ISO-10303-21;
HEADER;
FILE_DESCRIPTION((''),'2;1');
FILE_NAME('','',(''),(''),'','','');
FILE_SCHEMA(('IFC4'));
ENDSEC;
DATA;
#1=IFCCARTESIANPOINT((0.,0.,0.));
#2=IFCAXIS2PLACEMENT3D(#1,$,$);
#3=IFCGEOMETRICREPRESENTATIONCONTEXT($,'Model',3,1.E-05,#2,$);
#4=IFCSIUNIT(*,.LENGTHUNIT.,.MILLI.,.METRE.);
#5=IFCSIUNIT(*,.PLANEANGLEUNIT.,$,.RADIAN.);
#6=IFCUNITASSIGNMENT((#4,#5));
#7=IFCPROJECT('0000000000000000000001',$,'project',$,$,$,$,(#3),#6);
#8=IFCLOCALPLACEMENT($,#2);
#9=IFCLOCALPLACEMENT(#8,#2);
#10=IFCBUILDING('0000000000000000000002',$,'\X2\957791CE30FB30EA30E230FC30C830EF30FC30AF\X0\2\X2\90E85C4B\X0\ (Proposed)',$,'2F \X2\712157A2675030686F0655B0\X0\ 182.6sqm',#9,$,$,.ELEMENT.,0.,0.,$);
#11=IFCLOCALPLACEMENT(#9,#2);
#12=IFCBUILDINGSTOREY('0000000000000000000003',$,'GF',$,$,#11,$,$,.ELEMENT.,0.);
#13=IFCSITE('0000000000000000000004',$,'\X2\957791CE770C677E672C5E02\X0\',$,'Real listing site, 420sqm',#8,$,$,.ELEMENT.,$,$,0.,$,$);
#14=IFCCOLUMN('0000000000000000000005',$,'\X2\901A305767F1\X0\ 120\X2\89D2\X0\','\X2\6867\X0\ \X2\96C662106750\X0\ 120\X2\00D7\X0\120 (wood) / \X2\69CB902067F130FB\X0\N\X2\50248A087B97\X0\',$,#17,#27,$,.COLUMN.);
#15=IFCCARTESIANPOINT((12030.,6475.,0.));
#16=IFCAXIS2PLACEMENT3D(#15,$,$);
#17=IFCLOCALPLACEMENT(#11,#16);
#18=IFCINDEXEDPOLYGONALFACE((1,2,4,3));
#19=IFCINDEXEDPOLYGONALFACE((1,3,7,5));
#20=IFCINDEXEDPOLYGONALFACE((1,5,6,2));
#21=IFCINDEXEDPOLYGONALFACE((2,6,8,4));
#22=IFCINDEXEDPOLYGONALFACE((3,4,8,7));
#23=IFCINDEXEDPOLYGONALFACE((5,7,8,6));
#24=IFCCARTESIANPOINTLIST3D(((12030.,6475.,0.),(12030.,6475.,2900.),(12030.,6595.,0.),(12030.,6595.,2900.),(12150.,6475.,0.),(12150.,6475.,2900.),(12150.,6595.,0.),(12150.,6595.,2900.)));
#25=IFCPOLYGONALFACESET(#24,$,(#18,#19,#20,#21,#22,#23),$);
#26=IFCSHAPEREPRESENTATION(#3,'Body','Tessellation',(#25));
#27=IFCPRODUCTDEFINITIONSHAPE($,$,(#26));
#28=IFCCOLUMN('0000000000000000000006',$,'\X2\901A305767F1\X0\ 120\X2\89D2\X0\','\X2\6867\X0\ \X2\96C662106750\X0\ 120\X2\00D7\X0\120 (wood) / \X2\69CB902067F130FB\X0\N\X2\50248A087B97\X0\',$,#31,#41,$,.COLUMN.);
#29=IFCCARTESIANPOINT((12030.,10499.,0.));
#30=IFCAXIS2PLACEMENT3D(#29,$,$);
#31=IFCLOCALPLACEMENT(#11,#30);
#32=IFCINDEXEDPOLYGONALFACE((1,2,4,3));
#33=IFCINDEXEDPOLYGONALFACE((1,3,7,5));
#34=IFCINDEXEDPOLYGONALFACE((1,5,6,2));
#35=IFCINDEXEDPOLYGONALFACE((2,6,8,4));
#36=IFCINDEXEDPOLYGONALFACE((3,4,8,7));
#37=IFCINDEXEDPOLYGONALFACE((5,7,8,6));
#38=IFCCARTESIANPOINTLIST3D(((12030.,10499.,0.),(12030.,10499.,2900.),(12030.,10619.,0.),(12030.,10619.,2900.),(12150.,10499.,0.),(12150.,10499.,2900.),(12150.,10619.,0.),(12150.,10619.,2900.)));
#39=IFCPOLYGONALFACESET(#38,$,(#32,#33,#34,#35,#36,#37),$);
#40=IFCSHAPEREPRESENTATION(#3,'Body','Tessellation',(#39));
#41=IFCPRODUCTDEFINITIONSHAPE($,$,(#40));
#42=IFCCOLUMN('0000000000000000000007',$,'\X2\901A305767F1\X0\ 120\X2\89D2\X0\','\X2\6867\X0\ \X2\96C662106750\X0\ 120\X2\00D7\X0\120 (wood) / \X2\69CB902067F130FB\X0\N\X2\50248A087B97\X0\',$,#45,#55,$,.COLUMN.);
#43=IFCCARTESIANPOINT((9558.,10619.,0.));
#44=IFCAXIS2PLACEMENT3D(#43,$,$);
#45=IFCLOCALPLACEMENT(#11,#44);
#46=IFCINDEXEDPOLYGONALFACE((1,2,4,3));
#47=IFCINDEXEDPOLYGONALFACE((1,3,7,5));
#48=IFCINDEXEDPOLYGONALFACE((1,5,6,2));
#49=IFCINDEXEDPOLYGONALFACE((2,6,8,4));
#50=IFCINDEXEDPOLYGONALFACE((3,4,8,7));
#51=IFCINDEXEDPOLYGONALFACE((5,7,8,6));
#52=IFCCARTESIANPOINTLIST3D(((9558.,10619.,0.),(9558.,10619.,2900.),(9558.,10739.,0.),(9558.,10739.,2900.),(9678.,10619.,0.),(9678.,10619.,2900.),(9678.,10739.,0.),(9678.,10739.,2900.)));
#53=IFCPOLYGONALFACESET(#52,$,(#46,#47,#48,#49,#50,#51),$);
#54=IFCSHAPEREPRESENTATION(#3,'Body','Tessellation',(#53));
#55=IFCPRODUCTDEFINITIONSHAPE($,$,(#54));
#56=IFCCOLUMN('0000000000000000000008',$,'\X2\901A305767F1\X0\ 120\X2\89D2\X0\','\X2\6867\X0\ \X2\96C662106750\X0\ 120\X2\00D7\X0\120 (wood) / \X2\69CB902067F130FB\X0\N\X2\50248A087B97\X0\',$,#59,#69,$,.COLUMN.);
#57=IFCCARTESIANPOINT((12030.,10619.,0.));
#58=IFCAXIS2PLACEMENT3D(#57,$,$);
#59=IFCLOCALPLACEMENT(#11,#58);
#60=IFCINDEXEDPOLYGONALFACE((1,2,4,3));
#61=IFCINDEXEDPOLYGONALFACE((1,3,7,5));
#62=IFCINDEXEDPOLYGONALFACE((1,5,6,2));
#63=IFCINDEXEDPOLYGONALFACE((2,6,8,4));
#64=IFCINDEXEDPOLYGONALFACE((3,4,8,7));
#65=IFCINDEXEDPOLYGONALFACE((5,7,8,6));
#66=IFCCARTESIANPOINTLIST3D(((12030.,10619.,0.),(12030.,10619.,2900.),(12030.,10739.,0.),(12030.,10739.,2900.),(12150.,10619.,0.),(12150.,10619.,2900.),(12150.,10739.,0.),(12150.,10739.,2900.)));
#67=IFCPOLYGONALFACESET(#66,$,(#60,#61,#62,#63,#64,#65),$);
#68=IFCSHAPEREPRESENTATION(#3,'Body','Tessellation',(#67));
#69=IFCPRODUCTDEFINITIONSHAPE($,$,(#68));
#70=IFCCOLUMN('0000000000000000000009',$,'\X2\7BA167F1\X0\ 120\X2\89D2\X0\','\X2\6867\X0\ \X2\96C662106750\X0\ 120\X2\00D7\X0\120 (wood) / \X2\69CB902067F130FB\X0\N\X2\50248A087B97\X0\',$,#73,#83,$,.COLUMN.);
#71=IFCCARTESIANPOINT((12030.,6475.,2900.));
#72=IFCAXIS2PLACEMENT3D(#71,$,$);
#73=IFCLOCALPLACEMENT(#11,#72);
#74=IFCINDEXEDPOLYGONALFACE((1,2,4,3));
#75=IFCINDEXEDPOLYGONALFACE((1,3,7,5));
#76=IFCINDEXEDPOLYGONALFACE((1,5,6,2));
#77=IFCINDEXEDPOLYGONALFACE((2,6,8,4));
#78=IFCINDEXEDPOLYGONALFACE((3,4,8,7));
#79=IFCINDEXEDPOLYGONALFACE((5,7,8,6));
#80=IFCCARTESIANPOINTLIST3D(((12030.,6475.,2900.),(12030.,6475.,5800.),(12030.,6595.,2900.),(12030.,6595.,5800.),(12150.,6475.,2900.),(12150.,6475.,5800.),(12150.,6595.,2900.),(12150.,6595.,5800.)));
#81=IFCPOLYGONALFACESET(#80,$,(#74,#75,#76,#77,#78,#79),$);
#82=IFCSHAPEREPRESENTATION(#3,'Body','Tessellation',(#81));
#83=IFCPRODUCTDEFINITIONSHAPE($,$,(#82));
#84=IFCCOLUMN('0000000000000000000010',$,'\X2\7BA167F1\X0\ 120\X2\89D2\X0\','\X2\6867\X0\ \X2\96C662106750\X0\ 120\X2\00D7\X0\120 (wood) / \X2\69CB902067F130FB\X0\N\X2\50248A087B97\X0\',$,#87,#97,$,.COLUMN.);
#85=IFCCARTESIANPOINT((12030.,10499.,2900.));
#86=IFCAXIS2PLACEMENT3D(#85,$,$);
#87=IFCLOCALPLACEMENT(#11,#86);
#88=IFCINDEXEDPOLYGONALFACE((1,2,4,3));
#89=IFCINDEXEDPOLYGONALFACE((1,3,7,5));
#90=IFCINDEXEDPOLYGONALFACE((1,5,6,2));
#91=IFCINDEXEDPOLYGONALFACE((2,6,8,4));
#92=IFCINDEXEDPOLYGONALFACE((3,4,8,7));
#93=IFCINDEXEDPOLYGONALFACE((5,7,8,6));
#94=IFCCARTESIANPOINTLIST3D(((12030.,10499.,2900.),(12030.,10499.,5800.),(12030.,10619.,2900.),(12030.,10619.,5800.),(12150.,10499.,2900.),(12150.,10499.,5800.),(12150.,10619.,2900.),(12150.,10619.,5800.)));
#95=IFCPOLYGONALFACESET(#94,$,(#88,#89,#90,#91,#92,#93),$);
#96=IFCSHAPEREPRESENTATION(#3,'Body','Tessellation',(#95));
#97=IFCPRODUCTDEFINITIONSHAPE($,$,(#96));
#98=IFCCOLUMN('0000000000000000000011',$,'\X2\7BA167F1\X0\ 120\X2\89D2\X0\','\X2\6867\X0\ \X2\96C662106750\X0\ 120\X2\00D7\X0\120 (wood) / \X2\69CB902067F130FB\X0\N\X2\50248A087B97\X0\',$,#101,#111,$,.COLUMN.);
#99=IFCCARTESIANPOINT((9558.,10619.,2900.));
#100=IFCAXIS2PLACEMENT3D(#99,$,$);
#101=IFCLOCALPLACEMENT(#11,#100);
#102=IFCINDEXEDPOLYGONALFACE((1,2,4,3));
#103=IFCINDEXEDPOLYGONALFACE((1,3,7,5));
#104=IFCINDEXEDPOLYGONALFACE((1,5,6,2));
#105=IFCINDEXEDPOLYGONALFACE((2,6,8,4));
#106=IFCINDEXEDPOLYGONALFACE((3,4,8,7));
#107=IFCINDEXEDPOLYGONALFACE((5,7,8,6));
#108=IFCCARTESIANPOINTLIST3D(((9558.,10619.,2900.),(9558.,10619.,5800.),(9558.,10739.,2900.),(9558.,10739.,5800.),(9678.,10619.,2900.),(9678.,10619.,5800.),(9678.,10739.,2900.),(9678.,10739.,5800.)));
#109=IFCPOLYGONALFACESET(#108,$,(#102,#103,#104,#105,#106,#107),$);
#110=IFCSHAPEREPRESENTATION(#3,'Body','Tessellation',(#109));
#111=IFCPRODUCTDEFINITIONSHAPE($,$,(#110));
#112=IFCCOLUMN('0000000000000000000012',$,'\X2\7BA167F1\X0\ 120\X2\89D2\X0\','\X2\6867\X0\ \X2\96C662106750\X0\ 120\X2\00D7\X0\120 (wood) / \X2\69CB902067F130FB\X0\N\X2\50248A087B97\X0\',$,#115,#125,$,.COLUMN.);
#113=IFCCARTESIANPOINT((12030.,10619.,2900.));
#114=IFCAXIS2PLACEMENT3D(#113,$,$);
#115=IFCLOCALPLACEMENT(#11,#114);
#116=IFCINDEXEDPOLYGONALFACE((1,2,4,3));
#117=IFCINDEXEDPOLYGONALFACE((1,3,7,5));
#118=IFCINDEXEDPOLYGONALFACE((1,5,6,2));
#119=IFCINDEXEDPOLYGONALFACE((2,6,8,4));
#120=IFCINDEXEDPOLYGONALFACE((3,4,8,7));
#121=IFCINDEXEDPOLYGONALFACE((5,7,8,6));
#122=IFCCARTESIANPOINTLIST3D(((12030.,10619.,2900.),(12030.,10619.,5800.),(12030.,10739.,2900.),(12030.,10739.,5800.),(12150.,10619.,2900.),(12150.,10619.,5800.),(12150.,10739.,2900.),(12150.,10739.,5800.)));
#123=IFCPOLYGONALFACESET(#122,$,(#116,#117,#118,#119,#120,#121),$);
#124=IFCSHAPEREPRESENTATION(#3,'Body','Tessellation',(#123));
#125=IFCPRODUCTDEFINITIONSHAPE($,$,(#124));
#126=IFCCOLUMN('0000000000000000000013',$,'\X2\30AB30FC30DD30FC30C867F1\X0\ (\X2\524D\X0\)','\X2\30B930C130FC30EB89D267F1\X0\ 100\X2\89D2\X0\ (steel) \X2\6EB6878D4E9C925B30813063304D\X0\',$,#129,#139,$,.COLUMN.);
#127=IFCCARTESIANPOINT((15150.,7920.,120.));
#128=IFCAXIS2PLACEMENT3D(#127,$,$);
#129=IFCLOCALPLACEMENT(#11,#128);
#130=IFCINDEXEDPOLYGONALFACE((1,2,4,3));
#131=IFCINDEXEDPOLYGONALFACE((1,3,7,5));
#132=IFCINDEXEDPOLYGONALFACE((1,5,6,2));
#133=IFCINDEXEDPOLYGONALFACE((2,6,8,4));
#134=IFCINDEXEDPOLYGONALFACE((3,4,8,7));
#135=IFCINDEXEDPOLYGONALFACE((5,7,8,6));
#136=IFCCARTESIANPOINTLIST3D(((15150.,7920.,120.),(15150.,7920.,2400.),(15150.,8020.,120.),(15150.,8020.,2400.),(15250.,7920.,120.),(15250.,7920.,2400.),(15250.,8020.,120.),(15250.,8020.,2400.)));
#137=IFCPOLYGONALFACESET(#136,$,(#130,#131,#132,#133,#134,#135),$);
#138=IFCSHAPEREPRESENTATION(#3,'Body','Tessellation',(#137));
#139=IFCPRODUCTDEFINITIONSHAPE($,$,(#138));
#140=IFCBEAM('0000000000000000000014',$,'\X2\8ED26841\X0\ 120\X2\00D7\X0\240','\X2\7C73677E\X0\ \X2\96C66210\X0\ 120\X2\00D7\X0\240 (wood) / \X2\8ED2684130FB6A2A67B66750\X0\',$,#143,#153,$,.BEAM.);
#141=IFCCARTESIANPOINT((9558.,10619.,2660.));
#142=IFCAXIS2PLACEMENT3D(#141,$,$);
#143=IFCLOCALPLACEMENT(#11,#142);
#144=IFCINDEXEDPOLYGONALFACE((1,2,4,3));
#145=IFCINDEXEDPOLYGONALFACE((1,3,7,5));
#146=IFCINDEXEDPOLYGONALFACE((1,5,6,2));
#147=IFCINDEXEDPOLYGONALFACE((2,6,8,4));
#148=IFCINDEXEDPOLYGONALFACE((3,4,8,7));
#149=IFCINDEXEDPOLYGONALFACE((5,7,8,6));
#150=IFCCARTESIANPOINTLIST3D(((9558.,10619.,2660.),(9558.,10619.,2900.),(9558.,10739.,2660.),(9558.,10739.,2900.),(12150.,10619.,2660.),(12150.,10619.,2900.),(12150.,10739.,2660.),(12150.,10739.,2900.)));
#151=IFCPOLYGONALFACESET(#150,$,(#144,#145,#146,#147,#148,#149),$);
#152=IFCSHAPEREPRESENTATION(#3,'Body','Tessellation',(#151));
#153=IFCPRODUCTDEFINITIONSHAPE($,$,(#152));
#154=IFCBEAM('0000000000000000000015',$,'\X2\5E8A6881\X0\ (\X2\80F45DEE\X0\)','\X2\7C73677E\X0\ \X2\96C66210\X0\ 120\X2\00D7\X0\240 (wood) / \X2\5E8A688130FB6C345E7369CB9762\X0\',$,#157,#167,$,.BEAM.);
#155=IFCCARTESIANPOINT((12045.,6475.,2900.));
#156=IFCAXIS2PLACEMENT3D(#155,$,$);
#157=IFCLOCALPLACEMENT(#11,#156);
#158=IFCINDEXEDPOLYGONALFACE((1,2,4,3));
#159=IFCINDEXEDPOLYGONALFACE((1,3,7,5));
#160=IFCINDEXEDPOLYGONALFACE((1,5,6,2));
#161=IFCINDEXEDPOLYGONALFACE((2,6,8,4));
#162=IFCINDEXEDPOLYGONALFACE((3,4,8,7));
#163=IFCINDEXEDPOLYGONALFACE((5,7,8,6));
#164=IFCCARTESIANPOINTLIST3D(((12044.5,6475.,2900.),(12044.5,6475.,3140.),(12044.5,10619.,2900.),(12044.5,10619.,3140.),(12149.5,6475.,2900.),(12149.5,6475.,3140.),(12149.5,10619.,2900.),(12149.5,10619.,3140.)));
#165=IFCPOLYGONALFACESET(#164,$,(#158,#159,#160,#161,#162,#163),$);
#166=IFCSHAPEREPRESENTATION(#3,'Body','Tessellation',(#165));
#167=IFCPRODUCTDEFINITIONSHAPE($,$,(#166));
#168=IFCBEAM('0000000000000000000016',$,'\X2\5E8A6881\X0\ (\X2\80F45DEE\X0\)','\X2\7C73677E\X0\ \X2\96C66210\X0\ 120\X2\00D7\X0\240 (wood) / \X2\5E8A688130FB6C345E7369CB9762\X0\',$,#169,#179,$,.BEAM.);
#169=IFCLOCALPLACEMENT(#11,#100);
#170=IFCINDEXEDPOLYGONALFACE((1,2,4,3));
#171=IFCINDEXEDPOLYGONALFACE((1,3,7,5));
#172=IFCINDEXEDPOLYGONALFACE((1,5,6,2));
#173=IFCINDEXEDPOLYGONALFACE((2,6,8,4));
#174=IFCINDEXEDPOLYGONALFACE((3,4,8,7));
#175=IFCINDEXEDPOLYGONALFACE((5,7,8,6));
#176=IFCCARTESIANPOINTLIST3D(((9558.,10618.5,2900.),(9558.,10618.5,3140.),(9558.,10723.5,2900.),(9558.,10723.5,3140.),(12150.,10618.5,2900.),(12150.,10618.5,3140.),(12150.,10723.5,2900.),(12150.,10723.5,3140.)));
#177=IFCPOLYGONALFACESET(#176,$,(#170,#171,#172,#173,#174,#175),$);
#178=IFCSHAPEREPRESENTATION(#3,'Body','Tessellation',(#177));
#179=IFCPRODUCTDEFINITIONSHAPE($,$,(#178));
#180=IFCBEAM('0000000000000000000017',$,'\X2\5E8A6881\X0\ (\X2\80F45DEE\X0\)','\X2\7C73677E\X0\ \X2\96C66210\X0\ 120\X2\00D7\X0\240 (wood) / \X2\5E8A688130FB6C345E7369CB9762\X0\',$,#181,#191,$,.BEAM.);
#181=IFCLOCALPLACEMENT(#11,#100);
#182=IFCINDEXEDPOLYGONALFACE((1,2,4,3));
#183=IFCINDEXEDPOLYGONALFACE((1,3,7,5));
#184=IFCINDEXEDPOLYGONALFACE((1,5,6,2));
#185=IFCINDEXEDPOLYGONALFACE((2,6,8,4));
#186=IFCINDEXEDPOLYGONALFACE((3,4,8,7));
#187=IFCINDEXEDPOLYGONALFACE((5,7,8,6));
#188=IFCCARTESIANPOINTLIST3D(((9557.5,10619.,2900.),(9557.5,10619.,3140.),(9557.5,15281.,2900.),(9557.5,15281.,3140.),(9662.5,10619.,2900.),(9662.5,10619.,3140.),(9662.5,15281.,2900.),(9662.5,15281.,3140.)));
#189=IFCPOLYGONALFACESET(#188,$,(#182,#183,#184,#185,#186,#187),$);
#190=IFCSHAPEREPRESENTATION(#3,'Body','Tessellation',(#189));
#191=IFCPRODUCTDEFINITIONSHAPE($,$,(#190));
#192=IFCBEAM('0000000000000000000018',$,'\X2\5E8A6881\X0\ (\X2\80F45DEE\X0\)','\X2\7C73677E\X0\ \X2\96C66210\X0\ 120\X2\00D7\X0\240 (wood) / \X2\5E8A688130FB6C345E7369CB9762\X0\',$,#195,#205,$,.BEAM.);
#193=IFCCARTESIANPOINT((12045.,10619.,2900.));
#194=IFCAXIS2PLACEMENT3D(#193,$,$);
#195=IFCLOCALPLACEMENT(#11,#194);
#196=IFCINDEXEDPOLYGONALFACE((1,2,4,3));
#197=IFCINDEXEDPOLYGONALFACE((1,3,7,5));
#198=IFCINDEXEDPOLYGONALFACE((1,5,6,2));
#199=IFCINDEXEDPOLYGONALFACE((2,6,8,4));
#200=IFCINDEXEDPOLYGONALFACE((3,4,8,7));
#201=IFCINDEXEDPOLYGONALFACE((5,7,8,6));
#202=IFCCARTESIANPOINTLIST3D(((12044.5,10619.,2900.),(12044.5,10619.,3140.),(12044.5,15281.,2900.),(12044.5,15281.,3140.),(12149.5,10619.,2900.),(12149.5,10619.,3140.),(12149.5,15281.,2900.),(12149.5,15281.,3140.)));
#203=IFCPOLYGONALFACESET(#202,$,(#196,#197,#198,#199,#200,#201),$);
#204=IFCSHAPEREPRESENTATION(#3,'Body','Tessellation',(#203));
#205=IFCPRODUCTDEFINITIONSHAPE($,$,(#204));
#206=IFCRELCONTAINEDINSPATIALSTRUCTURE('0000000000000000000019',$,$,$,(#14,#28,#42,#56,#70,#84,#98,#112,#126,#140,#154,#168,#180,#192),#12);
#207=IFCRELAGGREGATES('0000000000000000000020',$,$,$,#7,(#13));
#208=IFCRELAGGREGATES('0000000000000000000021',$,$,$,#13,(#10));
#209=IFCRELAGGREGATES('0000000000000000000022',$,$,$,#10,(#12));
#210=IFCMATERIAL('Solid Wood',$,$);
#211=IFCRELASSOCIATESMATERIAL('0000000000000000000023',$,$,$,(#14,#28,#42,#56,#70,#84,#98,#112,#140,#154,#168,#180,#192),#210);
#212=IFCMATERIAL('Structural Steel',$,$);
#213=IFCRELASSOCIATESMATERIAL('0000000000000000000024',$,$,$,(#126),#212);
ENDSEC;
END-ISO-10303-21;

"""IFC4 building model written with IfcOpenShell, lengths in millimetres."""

from ifc_helpers import new_model, si_unit, frame, frame_2d, origin, place, context, project, spatial, rectangle, extrude, material, element, save


model = new_model("IFC4")

# Units and contexts
model_context = context("Model", 3, precision=1e-05, world=origin())
ifc_project = project(units=[si_unit("LENGTHUNIT", "METRE", prefix="MILLI"), si_unit("PLANEANGLEUNIT", "RADIAN")], contexts=[model_context])

# Site, building, storey
site_placement = place(None, origin())
site = spatial("IfcSite", under=ifc_project, at=site_placement, Name="長野県松本市", ObjectType="Real listing site, 420sqm", CompositionType="ELEMENT", RefElevation=0.0)
building_placement = place(site_placement, origin())
building = spatial("IfcBuilding", under=site, at=building_placement, Name="長野・リモートワーク2部屋 (Proposed)", ObjectType="2F 無垢材と漆喰 182.6sqm", CompositionType="ELEMENT", ElevationOfRefHeight=0.0, ElevationOfTerrain=0.0)
storey_placement = place(building_placement, origin())
storey = spatial("IfcBuildingStorey", under=building, at=storey_placement, Name="GF", CompositionType="ELEMENT", Elevation=0.0)

# Columns
ifc_material_1 = material(Name="Solid Wood")
column_1_placement = place(storey_placement, frame((12030.0, 6475.0, 0.0)))
element("IfcColumn", 1, at=column_1_placement, inside=storey, material=ifc_material_1, Name="通し柱 120角", Description="桧 集成材 120×120 (wood) / 構造柱・N値計算", PredefinedType="COLUMN", context=model_context, shape_type="SweptSolid", body=[
    extrude(rectangle(XDim=120.0, YDim=120.0, at=frame_2d((60.0, 60.0))), frame((12030.0, 6475.0, 0.0)), (0.0, 0.0, 1.0), 2900.0),
])
column_2_placement = place(storey_placement, frame((12030.0, 10499.0, 0.0)))
element("IfcColumn", 2, at=column_2_placement, inside=storey, material=ifc_material_1, Name="通し柱 120角", Description="桧 集成材 120×120 (wood) / 構造柱・N値計算", PredefinedType="COLUMN", context=model_context, shape_type="SweptSolid", body=[
    extrude(rectangle(XDim=120.0, YDim=120.0, at=frame_2d((60.0, 60.0))), frame((12030.0, 10499.0, 0.0)), (0.0, 0.0, 1.0), 2900.0),
])
column_3_placement = place(storey_placement, frame((9558.0, 10619.0, 0.0)))
element("IfcColumn", 3, at=column_3_placement, inside=storey, material=ifc_material_1, Name="通し柱 120角", Description="桧 集成材 120×120 (wood) / 構造柱・N値計算", PredefinedType="COLUMN", context=model_context, shape_type="SweptSolid", body=[
    extrude(rectangle(XDim=120.0, YDim=120.0, at=frame_2d((60.0, 60.0))), frame((9558.0, 10619.0, 0.0)), (0.0, 0.0, 1.0), 2900.0),
])
column_4_placement = place(storey_placement, frame((12030.0, 10619.0, 0.0)))
element("IfcColumn", 4, at=column_4_placement, inside=storey, material=ifc_material_1, Name="通し柱 120角", Description="桧 集成材 120×120 (wood) / 構造柱・N値計算", PredefinedType="COLUMN", context=model_context, shape_type="SweptSolid", body=[
    extrude(rectangle(XDim=120.0, YDim=120.0, at=frame_2d((60.0, 60.0))), frame((12030.0, 10619.0, 0.0)), (0.0, 0.0, 1.0), 2900.0),
])
column_5_placement = place(storey_placement, frame((12030.0, 6475.0, 2900.0)))
element("IfcColumn", 5, at=column_5_placement, inside=storey, material=ifc_material_1, Name="管柱 120角", Description="桧 集成材 120×120 (wood) / 構造柱・N値計算", PredefinedType="COLUMN", context=model_context, shape_type="SweptSolid", body=[
    extrude(rectangle(XDim=120.0, YDim=120.0, at=frame_2d((60.0, 60.0))), frame((12030.0, 6475.0, 2900.0)), (0.0, 0.0, 1.0), 2900.0),
])
column_6_placement = place(storey_placement, frame((12030.0, 10499.0, 2900.0)))
element("IfcColumn", 6, at=column_6_placement, inside=storey, material=ifc_material_1, Name="管柱 120角", Description="桧 集成材 120×120 (wood) / 構造柱・N値計算", PredefinedType="COLUMN", context=model_context, shape_type="SweptSolid", body=[
    extrude(rectangle(XDim=120.0, YDim=120.0, at=frame_2d((60.0, 60.0))), frame((12030.0, 10499.0, 2900.0)), (0.0, 0.0, 1.0), 2900.0),
])
column_7_placement = place(storey_placement, frame((9558.0, 10619.0, 2900.0)))
element("IfcColumn", 7, at=column_7_placement, inside=storey, material=ifc_material_1, Name="管柱 120角", Description="桧 集成材 120×120 (wood) / 構造柱・N値計算", PredefinedType="COLUMN", context=model_context, shape_type="SweptSolid", body=[
    extrude(rectangle(XDim=120.0, YDim=120.0, at=frame_2d((60.0, 60.0))), frame((9558.0, 10619.0, 2900.0)), (0.0, 0.0, 1.0), 2900.0),
])
column_8_placement = place(storey_placement, frame((12030.0, 10619.0, 2900.0)))
element("IfcColumn", 8, at=column_8_placement, inside=storey, material=ifc_material_1, Name="管柱 120角", Description="桧 集成材 120×120 (wood) / 構造柱・N値計算", PredefinedType="COLUMN", context=model_context, shape_type="SweptSolid", body=[
    extrude(rectangle(XDim=120.0, YDim=120.0, at=frame_2d((60.0, 60.0))), frame((12030.0, 10619.0, 2900.0)), (0.0, 0.0, 1.0), 2900.0),
])
ifc_material_2 = material(Name="Structural Steel")
column_9_placement = place(storey_placement, frame((15150.0, 7920.0, 120.0)))
element("IfcColumn", 9, at=column_9_placement, inside=storey, material=ifc_material_2, Name="カーポート柱 (前)", Description="スチール角柱 100角 (steel) 溶融亜鉛めっき", PredefinedType="COLUMN", context=model_context, shape_type="SweptSolid", body=[
    extrude(rectangle(XDim=100.0, YDim=100.0, at=frame_2d((50.0, 50.0))), frame((15150.0, 7920.0, 120.0)), (0.0, 0.0, 1.0), 2280.0),
])

# Beams
beam_1_placement = place(storey_placement, frame((9558.0, 10619.0, 2660.0)))
element("IfcBeam", 10, at=beam_1_placement, inside=storey, material=ifc_material_1, Name="軒桁 120×240", Description="米松 集成 120×240 (wood) / 軒桁・横架材", PredefinedType="BEAM", context=model_context, shape_type="SweptSolid", body=[
    extrude(rectangle(XDim=2592.0, YDim=120.0, at=frame_2d((1296.0, 60.0))), frame((9558.0, 10619.0, 2660.0)), (0.0, 0.0, 1.0), 240.0),
])
beam_2_placement = place(storey_placement, frame((12045.0, 6475.0, 2900.0)))
element("IfcBeam", 11, at=beam_2_placement, inside=storey, material=ifc_material_1, Name="床梁 (胴差)", Description="米松 集成 120×240 (wood) / 床梁・水平構面", PredefinedType="BEAM", context=model_context, shape_type="SweptSolid", body=[
    extrude(rectangle(XDim=105.0, YDim=4144.0, at=frame_2d((52.0, 2072.0))), frame((12045.0, 6475.0, 2900.0)), (0.0, 0.0, 1.0), 240.0),
])
beam_3_placement = place(storey_placement, frame((9558.0, 10619.0, 2900.0)))
element("IfcBeam", 12, at=beam_3_placement, inside=storey, material=ifc_material_1, Name="床梁 (胴差)", Description="米松 集成 120×240 (wood) / 床梁・水平構面", PredefinedType="BEAM", context=model_context, shape_type="SweptSolid", body=[
    extrude(rectangle(XDim=2592.0, YDim=105.0, at=frame_2d((1296.0, 52.0))), frame((9558.0, 10619.0, 2900.0)), (0.0, 0.0, 1.0), 240.0),
])
beam_4_placement = place(storey_placement, frame((9558.0, 10619.0, 2900.0)))
element("IfcBeam", 13, at=beam_4_placement, inside=storey, material=ifc_material_1, Name="床梁 (胴差)", Description="米松 集成 120×240 (wood) / 床梁・水平構面", PredefinedType="BEAM", context=model_context, shape_type="SweptSolid", body=[
    extrude(rectangle(XDim=105.0, YDim=4662.0, at=frame_2d((52.0, 2331.0))), frame((9558.0, 10619.0, 2900.0)), (0.0, 0.0, 1.0), 240.0),
])
beam_5_placement = place(storey_placement, frame((12045.0, 10619.0, 2900.0)))
element("IfcBeam", 14, at=beam_5_placement, inside=storey, material=ifc_material_1, Name="床梁 (胴差)", Description="米松 集成 120×240 (wood) / 床梁・水平構面", PredefinedType="BEAM", context=model_context, shape_type="SweptSolid", body=[
    extrude(rectangle(XDim=105.0, YDim=4662.0, at=frame_2d((52.0, 2331.0))), frame((12045.0, 10619.0, 2900.0)), (0.0, 0.0, 1.0), 240.0),
])

save(model, "model.ifc")
